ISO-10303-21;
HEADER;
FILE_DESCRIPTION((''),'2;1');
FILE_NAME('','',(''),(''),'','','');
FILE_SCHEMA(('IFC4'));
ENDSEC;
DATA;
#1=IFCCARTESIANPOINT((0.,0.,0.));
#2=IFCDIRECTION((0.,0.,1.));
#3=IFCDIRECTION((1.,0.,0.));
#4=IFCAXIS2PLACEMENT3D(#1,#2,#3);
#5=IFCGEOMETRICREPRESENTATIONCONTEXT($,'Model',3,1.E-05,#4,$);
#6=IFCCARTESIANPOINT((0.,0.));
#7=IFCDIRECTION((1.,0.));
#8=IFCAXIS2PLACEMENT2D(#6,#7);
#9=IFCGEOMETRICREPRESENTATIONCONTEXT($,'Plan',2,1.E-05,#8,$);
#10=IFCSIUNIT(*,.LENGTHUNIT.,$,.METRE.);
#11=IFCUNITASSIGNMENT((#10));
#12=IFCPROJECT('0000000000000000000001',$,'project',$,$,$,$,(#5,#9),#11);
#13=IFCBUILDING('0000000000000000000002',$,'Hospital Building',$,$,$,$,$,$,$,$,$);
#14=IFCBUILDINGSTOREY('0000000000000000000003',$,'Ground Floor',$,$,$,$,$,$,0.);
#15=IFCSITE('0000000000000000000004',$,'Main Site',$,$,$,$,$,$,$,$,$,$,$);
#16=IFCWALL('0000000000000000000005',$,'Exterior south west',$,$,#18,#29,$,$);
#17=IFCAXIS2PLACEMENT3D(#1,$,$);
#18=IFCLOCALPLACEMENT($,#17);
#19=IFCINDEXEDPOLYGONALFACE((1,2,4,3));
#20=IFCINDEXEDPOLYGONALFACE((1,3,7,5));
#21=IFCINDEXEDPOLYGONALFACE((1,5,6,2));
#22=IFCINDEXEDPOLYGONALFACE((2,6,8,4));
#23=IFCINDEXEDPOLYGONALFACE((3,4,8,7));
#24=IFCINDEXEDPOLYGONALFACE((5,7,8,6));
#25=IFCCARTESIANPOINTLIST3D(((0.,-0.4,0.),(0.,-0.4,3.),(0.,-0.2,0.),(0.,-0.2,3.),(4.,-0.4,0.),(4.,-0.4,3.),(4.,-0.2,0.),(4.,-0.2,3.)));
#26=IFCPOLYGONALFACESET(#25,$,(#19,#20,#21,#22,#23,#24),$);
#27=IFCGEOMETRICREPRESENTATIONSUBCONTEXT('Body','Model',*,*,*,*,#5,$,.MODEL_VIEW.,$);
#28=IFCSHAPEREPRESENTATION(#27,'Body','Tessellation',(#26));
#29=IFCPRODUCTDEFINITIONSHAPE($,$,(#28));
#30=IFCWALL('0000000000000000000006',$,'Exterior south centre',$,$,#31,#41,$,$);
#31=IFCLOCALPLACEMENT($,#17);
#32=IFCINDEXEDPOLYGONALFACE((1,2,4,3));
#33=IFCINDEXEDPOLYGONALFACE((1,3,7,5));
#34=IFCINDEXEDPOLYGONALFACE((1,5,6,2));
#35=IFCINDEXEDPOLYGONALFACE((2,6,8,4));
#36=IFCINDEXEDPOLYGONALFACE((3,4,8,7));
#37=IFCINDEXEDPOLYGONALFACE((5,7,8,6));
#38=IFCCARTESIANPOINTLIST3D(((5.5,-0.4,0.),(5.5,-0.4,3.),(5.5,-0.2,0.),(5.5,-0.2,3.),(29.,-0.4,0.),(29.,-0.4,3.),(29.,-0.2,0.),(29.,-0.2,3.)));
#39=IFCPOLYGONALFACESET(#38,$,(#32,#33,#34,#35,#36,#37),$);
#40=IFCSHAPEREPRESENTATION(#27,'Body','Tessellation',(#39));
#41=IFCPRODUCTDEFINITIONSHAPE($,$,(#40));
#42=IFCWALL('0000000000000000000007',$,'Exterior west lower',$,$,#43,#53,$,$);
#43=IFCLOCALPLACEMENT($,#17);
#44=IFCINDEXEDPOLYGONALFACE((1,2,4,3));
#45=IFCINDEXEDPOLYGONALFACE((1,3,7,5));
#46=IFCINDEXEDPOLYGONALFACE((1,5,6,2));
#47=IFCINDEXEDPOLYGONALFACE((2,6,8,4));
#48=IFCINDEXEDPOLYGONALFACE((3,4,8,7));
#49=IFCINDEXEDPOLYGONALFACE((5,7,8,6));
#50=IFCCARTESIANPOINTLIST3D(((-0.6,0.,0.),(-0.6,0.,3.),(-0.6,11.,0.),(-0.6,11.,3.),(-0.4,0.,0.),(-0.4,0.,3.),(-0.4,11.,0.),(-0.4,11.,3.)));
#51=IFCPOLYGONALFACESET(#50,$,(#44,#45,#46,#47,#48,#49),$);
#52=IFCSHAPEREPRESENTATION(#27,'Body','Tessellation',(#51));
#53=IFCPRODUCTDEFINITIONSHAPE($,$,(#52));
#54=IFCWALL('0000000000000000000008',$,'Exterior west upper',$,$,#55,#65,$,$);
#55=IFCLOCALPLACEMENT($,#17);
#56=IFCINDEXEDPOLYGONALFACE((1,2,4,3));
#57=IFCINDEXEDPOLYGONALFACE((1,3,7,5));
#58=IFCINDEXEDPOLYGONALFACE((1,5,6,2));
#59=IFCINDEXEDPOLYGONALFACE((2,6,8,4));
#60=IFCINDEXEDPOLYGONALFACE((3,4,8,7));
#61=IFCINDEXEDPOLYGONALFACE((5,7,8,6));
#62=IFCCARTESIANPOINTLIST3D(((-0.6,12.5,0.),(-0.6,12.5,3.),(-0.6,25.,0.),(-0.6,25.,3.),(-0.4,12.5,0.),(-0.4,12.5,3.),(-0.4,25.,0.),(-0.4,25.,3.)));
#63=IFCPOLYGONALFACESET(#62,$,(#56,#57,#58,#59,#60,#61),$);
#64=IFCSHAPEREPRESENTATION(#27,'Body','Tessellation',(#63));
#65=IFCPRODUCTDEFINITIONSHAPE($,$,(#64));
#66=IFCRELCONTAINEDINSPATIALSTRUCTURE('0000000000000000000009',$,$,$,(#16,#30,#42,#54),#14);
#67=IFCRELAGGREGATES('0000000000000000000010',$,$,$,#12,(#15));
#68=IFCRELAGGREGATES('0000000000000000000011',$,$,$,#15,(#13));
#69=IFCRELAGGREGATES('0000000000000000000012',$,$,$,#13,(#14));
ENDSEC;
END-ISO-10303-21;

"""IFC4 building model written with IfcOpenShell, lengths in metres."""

from ifc_helpers import new_model, si_unit, frame, origin_with_axes, origin_2d_with_axis, place, context, subcontext, project, spatial, indexed_curve, outline, extrude, element, save


model = new_model("IFC4")

# Units and contexts
model_context = context("Model", 3, precision=1e-05, world=origin_with_axes())
plan_context = context("Plan", 2, precision=1e-05, world=origin_2d_with_axis())
body_context = subcontext(model_context, "Body", "Model", "MODEL_VIEW")
ifc_project = project(units=[si_unit("LENGTHUNIT", "METRE")], contexts=[model_context, plan_context])

# Site, building, storey
site = spatial("IfcSite", under=ifc_project, Name="Main Site")
building = spatial("IfcBuilding", under=site, Name="Hospital Building")
storey = spatial("IfcBuildingStorey", under=building, Name="Ground Floor", Elevation=0.0)

# Walls
wall_1_placement = place(None, frame((0.0, -0.4, 0.0), z_axis=(0.0, 0.0, 1.0), x_axis=(1.0, 0.0, 0.0)))
element("IfcWall", 1, at=wall_1_placement, inside=storey, Name="Exterior south west", context=body_context, shape_type="SweptSolid", body=[
    extrude(outline(indexed_curve([(0.0, 0.0), (0.0, 0.2), (4.0, 0.2), (4.0, 0.0), (0.0, 0.0)], self_intersect=False)), origin_with_axes(), (0.0, 0.0, 1.0), 3.0),
])
wall_2_placement = place(None, frame((5.5, -0.4, 0.0), z_axis=(0.0, 0.0, 1.0), x_axis=(1.0, 0.0, 0.0)))
element("IfcWall", 2, at=wall_2_placement, inside=storey, Name="Exterior south centre", context=body_context, shape_type="SweptSolid", body=[
    extrude(outline(indexed_curve([(0.0, 0.0), (0.0, 0.2), (23.5, 0.2), (23.5, 0.0), (0.0, 0.0)], self_intersect=False)), origin_with_axes(), (0.0, 0.0, 1.0), 3.0),
])
wall_3_placement = place(None, frame((-0.4, 0.0, 0.0), z_axis=(0.0, 0.0, 1.0), x_axis=(0.0, 1.0, 0.0)))
element("IfcWall", 3, at=wall_3_placement, inside=storey, Name="Exterior west lower", context=body_context, shape_type="SweptSolid", body=[
    extrude(outline(indexed_curve([(0.0, 0.0), (0.0, 0.2), (11.0, 0.2), (11.0, 0.0), (0.0, 0.0)], self_intersect=False)), origin_with_axes(), (0.0, 0.0, 1.0), 3.0),
])
wall_4_placement = place(None, frame((-0.4, 12.5, 0.0), z_axis=(0.0, 0.0, 1.0), x_axis=(0.0, 1.0, 0.0)))
element("IfcWall", 4, at=wall_4_placement, inside=storey, Name="Exterior west upper", context=body_context, shape_type="SweptSolid", body=[
    extrude(outline(indexed_curve([(0.0, 0.0), (0.0, 0.2), (12.5, 0.2), (12.5, 0.0), (0.0, 0.0)], self_intersect=False)), origin_with_axes(), (0.0, 0.0, 1.0), 3.0),
])

save(model, "model.ifc")
